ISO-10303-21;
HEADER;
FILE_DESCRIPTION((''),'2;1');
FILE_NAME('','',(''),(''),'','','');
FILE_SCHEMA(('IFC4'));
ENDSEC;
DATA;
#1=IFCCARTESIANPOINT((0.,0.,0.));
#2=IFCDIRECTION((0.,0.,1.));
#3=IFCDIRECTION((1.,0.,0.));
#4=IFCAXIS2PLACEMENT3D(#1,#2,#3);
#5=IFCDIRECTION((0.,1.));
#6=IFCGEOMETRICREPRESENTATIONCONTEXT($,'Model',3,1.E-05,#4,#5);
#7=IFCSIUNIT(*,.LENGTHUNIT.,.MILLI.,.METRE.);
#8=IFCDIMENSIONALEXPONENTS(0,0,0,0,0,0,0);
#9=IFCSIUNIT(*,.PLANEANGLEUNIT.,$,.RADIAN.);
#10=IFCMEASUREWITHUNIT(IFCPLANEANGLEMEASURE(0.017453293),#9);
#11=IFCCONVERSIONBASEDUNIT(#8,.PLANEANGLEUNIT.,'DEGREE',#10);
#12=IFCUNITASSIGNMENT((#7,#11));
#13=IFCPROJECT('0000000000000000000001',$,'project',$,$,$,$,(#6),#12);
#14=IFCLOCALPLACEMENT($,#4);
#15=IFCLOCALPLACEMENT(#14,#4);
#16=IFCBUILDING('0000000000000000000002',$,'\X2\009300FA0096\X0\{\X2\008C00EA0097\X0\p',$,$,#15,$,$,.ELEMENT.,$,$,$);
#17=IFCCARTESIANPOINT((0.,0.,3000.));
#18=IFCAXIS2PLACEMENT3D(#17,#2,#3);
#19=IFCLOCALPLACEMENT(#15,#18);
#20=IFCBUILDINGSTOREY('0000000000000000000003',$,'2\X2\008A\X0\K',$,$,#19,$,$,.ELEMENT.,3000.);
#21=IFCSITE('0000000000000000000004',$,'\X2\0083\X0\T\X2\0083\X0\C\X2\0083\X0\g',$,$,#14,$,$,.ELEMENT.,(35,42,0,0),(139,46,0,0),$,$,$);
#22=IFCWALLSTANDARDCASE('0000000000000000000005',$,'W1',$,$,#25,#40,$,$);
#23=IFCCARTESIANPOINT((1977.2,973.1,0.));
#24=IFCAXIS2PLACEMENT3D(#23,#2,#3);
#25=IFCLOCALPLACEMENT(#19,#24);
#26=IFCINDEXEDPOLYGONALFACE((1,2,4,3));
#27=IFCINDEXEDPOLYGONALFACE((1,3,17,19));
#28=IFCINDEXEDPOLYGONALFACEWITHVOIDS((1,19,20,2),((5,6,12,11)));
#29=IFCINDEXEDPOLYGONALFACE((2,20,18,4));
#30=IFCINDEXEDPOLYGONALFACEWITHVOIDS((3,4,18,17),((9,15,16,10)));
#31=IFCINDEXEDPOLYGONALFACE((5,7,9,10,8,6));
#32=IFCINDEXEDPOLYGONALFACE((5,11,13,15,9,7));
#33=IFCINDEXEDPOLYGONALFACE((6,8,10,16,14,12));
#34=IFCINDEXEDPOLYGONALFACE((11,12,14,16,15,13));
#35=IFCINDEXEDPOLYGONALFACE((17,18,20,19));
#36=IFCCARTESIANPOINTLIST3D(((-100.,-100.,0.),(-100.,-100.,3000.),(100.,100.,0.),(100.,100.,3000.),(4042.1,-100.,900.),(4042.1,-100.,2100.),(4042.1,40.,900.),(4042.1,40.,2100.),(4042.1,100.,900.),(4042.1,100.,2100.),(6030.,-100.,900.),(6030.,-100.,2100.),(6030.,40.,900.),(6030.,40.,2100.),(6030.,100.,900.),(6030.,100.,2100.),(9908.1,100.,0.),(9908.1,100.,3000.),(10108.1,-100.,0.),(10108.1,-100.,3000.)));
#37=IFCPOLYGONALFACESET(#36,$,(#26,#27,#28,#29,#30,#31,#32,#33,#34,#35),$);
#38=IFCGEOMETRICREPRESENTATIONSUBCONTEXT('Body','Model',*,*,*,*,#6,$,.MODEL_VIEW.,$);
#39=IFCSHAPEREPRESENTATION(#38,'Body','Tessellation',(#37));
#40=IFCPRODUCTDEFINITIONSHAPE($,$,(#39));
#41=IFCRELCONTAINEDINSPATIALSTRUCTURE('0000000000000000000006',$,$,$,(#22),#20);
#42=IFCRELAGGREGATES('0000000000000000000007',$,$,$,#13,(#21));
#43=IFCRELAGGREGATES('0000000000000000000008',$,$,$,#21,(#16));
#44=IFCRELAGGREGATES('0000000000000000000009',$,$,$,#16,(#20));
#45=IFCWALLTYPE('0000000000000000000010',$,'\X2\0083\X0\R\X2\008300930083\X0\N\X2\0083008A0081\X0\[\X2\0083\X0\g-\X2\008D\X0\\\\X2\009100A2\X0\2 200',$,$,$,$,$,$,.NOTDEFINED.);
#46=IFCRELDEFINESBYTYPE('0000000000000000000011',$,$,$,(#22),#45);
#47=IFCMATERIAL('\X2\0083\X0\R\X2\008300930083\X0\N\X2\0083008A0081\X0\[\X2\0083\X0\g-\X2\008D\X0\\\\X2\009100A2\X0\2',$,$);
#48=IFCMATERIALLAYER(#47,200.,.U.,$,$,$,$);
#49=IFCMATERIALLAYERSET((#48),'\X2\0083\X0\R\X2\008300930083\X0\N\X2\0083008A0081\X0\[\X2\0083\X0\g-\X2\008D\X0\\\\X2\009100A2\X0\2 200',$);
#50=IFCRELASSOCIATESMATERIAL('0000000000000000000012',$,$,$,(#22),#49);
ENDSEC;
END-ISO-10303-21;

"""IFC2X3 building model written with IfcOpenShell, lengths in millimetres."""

from ifc_helpers import new_model, entity, si_unit, converted_unit, direction, frame, origin_with_axes, origin_2d_with_axis, place, context, subcontext, project, spatial, polyline, rectangle, outline, extrude, material, layer, layer_set, layer_usage, type_object, element, save


model = new_model("IFC2X3")

# Units and contexts
model_context = context("Model", 3, precision=1e-05, world=origin_with_axes(), true_north=direction((0.0, 1.0)))
body_context = subcontext(model_context, "Body", "Model", "MODEL_VIEW")
ifc_project = project(units=[si_unit("LENGTHUNIT", "METRE", prefix="MILLI"), converted_unit("PLANEANGLEUNIT", "DEGREE", entity("IfcPlaneAngleMeasure", 0.017453293), si_unit("PLANEANGLEUNIT", "RADIAN"), dimensions=[0, 0, 0, 0, 0, 0, 0])], contexts=[model_context])

# Site, building, storey
site_placement = place(None, origin_with_axes())
site = spatial("IfcSite", under=ifc_project, at=site_placement, Name="\u0083T\u0083C\u0083g", CompositionType="ELEMENT", RefLatitude=(35, 42, 0, 0), RefLongitude=(139, 46, 0, 0))
building_placement = place(site_placement, origin_with_axes())
building = spatial("IfcBuilding", under=site, at=building_placement, Name="\u0093ú\u0096{\u008cê\u0097p", CompositionType="ELEMENT")
storey_placement = place(building_placement, frame((0.0, 0.0, 3000.0), z_axis=(0.0, 0.0, 1.0), x_axis=(1.0, 0.0, 0.0)))
storey = spatial("IfcBuildingStorey", under=building, at=storey_placement, Name="2\u008aK", CompositionType="ELEMENT", Elevation=3000.0)

# Shared definitions
ifc_material = material(Name="\u0083R\u0083\u0093\u0083N\u0083\u008a\u0081[\u0083g-\u008d\\\u0091¢2")

# Shared definitions
ifc_layer = layer(ifc_material, 200.0, ventilated="UNKNOWN")
ifc_layer_set = layer_set([ifc_layer], Name="\u0083R\u0083\u0093\u0083N\u0083\u008a\u0081[\u0083g-\u008d\\\u0091¢2 200")

# Shared definitions
wall_type = type_object("IfcWallType", Name="\u0083R\u0083\u0093\u0083N\u0083\u008a\u0081[\u0083g-\u008d\\\u0091¢2 200", PredefinedType="NOTDEFINED")

# Wall, opening
ifc_layer_usage_1 = layer_usage(ifc_layer_set, "AXIS2", "NEGATIVE", 100.0)
wall_1_placement = place(storey_placement, frame((1977.2, 973.1, 0.0), z_axis=(0.0, 0.0, 1.0), x_axis=(1.0, 0.0, 0.0)))
wall_1 = element("IfcWallStandardCase", 1, at=wall_1_placement, inside=storey, type_object=wall_type, material=ifc_layer_usage_1, Name="W1", context=body_context, shape_type="SweptSolid", body=[
    extrude(outline(polyline([(-100.0, -100.0), (10108.1, -100.0), (9908.1, 100.0), (100.0, 100.0), (-100.0, -100.0)])), origin_with_axes(), (0.0, 0.0, 1.0), 3000.0),
])
opening_placement = place(wall_1_placement, frame((5036.0, 0.0, 900.0), z_axis=(0.0, 0.0, 1.0), x_axis=(1.0, 0.0, 0.0)))
element("IfcOpeningElement", 2, at=opening_placement, cuts=wall_1, context=body_context, shape_type="SweptSolid", body=[
    extrude(rectangle(XDim=1987.9, YDim=1200.0, at=origin_2d_with_axis()), frame((0.0, 40.0, 600.0), z_axis=(0.0, -1.0, 0.0), x_axis=(1.0, 0.0, 0.0)), (0.0, 0.0, -1.0), 200.0),
    extrude(rectangle(XDim=1987.9, YDim=1200.0, at=origin_2d_with_axis()), frame((0.0, 40.0, 600.0), z_axis=(0.0, 1.0, 0.0), x_axis=(1.0, 0.0, 0.0)), (0.0, 0.0, -1.0), 200.0),
    extrude(rectangle(XDim=2047.9, YDim=1260.0, at=origin_2d_with_axis()), frame((0.0, 240.0, 600.0), z_axis=(0.0, -1.0, 0.0), x_axis=(1.0, 0.0, 0.0)), (0.0, 0.0, -1.0), 400.0),
])

save(model, "model.ifc")
